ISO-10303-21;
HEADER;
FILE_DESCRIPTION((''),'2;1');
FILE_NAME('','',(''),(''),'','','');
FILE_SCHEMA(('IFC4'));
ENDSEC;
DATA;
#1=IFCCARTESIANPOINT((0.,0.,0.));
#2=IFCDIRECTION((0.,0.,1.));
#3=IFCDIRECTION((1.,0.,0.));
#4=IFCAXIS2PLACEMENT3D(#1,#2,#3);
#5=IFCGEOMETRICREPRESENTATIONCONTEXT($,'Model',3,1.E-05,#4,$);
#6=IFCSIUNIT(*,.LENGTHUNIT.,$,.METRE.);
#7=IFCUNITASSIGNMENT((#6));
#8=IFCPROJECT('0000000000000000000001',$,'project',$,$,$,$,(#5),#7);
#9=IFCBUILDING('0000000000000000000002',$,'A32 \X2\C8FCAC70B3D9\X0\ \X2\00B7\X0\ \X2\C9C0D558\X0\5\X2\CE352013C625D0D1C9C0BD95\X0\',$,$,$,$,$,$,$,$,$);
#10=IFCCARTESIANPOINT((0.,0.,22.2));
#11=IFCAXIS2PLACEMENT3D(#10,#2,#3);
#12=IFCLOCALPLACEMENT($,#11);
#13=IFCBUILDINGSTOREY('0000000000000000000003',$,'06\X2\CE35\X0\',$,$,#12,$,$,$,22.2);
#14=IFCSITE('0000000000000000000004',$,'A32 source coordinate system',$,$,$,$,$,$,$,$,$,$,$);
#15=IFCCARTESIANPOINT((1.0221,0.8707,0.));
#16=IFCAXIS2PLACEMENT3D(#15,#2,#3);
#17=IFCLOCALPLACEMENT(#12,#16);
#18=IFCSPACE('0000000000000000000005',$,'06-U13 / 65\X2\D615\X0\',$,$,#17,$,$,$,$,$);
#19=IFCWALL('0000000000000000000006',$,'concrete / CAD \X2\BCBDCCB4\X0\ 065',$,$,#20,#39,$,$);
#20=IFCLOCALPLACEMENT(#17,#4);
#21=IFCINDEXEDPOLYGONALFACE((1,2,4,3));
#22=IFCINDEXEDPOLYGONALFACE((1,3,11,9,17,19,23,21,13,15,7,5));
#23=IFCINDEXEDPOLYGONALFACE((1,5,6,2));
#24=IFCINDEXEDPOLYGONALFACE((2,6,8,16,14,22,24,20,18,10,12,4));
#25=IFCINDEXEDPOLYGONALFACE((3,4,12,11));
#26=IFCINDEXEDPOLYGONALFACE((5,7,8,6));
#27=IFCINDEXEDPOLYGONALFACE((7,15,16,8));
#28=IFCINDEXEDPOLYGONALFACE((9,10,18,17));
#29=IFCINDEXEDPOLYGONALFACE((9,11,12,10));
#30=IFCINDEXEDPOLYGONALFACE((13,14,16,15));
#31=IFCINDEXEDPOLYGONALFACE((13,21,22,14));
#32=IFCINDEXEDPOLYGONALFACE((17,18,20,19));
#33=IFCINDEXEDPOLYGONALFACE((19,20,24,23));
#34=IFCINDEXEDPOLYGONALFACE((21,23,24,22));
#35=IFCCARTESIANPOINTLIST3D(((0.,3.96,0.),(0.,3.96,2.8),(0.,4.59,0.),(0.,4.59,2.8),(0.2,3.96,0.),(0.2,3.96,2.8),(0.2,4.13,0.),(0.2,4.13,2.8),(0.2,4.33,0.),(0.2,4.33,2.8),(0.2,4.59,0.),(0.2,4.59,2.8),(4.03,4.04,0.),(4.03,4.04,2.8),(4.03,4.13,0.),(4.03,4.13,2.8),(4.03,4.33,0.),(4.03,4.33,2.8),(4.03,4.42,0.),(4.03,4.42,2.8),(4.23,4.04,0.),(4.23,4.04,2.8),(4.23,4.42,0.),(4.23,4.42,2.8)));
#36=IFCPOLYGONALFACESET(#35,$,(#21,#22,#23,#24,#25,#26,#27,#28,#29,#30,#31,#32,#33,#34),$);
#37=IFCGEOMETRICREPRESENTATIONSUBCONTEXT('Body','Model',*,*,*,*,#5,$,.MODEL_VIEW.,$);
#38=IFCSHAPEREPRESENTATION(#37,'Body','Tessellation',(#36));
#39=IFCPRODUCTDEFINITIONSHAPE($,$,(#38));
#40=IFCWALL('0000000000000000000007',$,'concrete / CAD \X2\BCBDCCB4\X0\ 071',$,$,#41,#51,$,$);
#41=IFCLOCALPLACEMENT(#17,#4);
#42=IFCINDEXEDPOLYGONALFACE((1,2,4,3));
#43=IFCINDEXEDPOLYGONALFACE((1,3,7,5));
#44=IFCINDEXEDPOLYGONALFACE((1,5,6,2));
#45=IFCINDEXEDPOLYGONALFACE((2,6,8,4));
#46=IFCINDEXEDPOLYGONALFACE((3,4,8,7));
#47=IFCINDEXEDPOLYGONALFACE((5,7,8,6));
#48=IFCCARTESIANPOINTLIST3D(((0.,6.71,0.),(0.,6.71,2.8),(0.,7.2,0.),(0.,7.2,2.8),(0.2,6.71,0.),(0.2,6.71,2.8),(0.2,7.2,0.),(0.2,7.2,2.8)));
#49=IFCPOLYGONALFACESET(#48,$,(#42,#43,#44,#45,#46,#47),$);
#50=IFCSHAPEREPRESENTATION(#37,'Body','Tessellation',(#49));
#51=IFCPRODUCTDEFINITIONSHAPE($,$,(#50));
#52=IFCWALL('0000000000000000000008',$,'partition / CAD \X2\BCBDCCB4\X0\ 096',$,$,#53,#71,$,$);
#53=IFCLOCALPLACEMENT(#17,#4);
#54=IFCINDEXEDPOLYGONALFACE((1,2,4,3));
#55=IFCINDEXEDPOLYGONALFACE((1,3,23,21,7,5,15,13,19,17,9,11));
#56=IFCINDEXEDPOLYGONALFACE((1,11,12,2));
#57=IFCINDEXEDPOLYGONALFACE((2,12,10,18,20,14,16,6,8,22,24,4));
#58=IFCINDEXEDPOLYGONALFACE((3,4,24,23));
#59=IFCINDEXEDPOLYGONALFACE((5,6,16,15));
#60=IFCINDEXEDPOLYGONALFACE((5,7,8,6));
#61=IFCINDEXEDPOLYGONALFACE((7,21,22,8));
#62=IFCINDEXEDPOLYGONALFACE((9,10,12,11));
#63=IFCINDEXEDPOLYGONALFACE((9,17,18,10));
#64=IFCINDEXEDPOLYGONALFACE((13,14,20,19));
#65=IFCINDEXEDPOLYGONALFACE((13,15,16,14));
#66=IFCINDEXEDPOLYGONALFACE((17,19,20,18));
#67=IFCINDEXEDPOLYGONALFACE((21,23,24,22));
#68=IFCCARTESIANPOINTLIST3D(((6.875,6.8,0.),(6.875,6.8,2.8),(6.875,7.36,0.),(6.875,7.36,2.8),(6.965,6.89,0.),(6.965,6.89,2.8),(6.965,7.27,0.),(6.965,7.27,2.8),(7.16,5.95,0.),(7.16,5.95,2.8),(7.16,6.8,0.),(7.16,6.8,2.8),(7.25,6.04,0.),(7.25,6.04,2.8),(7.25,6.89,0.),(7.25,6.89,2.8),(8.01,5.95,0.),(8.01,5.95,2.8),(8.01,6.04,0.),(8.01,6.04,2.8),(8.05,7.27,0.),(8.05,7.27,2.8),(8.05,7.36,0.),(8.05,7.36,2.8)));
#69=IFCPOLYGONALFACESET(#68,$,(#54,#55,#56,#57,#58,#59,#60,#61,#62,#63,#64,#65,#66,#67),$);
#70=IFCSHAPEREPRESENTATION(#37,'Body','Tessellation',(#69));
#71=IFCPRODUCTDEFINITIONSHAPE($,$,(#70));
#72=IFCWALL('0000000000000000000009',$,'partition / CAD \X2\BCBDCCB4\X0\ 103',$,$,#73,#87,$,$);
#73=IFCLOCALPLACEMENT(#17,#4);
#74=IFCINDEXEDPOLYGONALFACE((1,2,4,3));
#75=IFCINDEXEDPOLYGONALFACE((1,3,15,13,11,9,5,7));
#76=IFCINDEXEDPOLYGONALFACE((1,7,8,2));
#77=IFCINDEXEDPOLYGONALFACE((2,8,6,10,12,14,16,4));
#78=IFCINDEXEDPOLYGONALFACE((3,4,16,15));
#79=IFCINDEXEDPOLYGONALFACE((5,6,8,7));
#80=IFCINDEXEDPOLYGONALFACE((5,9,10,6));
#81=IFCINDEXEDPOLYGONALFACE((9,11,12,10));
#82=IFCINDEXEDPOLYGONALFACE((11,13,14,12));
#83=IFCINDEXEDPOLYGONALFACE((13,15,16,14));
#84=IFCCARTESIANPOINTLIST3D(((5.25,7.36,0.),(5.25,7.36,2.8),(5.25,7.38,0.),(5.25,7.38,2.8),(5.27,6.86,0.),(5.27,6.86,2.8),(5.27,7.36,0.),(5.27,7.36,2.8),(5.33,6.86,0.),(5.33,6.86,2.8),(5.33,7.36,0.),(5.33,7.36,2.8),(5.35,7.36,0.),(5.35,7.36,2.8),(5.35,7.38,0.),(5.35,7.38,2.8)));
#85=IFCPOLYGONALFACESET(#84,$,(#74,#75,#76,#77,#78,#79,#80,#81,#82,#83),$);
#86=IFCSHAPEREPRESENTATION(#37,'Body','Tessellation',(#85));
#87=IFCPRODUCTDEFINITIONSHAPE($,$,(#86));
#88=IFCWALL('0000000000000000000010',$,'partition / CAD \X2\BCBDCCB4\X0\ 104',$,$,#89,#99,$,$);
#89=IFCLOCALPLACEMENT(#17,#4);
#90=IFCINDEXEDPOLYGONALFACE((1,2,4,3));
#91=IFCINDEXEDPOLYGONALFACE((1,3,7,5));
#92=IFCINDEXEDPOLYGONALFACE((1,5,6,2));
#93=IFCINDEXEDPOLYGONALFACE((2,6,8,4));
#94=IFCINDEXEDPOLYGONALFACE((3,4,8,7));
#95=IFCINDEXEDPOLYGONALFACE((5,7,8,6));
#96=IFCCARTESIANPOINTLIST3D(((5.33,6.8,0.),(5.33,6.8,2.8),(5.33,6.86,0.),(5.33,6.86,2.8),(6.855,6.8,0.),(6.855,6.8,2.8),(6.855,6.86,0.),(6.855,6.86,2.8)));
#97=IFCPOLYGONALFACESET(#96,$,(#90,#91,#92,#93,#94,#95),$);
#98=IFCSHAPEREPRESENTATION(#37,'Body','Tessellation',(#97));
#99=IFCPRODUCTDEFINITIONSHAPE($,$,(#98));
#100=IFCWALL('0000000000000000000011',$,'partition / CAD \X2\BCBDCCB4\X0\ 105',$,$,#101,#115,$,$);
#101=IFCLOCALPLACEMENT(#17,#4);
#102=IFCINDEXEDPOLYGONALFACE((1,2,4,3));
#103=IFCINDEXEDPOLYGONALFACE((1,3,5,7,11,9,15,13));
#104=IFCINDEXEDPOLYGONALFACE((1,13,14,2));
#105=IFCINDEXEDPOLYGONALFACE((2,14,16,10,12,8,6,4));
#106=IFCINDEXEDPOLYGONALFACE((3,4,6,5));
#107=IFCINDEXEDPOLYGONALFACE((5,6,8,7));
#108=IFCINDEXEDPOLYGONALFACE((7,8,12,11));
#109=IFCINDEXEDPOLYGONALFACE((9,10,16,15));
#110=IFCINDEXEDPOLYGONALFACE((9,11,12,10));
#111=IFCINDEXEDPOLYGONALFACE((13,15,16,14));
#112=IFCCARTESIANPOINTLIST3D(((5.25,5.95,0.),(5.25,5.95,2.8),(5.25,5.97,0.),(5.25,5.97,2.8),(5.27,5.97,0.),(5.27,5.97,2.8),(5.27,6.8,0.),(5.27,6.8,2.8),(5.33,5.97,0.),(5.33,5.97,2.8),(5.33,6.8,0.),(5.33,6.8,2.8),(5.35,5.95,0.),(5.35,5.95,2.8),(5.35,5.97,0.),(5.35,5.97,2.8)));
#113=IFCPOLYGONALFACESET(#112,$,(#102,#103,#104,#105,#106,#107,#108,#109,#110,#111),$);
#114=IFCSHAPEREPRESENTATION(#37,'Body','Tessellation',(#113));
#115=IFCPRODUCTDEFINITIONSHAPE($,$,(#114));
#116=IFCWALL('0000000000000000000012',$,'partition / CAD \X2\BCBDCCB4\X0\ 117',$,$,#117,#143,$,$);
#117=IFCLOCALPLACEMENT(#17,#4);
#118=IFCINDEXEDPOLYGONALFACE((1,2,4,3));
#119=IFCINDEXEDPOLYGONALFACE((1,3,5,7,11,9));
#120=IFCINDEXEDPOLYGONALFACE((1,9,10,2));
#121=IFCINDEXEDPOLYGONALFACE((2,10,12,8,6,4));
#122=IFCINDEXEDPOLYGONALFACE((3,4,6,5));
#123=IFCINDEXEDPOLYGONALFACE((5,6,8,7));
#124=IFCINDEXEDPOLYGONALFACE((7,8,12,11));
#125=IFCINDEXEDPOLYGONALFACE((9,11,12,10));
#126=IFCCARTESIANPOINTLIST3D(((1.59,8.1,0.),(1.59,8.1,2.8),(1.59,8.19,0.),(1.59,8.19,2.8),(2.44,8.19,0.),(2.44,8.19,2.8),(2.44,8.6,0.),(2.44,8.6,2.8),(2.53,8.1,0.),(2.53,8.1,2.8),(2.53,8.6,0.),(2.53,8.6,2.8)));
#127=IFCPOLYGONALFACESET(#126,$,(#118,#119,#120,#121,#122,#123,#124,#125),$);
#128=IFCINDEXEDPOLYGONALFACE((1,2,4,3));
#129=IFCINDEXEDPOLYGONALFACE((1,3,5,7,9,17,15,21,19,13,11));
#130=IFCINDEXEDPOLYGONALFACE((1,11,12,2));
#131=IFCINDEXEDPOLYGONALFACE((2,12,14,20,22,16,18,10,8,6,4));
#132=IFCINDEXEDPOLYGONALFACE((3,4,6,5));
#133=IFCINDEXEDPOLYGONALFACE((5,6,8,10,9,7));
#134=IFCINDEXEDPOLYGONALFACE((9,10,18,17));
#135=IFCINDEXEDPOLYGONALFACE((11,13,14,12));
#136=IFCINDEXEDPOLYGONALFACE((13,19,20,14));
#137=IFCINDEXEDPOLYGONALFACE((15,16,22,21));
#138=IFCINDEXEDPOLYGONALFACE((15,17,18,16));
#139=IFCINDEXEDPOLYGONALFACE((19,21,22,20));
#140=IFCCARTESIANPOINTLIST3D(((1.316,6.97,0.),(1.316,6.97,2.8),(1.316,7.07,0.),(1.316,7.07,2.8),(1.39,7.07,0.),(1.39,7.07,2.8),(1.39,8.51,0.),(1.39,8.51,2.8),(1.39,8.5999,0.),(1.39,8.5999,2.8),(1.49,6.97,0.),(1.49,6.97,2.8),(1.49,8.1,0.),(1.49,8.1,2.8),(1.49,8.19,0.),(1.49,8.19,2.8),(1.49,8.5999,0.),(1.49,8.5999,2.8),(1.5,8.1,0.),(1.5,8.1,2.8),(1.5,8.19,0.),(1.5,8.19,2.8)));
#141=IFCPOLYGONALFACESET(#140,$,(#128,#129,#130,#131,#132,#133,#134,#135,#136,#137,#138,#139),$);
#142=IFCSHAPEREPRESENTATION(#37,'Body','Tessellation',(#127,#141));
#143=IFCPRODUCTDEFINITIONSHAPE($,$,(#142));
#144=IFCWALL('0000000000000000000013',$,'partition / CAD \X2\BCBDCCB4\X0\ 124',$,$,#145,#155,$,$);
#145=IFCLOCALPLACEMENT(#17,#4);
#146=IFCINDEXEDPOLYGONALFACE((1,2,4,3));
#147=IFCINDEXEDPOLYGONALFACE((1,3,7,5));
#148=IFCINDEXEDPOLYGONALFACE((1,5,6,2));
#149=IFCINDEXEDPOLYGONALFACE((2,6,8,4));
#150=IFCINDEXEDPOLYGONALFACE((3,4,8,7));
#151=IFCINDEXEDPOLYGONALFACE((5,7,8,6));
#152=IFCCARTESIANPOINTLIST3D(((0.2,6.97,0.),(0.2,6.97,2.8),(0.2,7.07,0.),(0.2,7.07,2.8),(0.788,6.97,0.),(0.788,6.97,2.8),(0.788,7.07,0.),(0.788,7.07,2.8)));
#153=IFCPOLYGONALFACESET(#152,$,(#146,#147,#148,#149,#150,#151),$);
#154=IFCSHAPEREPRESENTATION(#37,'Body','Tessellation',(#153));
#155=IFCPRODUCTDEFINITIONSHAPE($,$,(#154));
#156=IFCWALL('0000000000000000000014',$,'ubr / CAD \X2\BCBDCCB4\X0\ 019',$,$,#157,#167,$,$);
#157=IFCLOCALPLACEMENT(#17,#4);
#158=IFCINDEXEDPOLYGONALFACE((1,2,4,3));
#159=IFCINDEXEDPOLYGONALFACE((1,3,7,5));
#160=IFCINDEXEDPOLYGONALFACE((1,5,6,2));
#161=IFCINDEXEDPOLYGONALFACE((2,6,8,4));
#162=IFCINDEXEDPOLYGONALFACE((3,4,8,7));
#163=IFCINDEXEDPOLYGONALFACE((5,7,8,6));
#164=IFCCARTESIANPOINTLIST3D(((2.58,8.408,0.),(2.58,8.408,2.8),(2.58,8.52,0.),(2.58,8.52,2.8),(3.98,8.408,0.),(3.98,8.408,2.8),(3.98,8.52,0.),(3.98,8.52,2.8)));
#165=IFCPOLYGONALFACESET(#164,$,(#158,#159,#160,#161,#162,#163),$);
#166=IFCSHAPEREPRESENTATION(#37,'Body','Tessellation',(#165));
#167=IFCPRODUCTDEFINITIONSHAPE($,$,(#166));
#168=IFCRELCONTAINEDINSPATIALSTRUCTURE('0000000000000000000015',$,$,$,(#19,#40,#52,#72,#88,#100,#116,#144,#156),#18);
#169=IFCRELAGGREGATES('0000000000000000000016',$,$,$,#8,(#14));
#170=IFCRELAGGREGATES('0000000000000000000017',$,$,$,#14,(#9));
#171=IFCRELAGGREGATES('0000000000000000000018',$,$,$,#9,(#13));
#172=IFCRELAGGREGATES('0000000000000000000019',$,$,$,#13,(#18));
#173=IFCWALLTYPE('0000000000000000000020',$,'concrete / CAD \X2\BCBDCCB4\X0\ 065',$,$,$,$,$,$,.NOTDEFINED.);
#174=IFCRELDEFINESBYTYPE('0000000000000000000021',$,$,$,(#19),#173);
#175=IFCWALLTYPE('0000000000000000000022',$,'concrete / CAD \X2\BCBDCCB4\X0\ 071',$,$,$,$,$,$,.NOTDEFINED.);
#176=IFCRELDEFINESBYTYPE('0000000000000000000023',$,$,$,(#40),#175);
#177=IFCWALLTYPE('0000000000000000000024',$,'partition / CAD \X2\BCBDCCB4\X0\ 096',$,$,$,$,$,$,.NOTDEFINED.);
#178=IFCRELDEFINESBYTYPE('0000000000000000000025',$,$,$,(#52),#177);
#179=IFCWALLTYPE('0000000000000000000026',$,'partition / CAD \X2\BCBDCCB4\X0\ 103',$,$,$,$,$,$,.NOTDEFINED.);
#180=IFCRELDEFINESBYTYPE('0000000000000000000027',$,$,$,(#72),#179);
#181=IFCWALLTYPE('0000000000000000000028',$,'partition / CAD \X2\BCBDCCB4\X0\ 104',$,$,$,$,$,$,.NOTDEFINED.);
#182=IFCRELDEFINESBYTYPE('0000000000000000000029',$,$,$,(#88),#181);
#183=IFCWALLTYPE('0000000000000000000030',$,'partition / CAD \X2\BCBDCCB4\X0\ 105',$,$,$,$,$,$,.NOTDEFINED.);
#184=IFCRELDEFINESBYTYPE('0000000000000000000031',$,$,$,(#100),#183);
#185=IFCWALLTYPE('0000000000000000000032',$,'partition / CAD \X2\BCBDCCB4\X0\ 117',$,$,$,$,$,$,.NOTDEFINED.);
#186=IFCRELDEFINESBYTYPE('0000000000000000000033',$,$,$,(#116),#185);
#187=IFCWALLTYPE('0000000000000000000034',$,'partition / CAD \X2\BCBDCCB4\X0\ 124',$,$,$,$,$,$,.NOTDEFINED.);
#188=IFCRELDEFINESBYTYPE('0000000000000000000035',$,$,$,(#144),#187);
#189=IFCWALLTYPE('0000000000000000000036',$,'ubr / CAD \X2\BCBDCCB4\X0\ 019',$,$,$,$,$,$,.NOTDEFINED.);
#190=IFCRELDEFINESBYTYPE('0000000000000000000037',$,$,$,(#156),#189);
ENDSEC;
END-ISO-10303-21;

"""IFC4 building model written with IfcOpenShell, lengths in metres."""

from ifc_helpers import new_model, si_unit, frame, origin, origin_with_axes, place, context, subcontext, project, spatial, polyline, outline, extrude, source, transform, mapped, type_object, type_shapes, element, save


model = new_model("IFC4")

# Units and contexts
model_context = context("Model", 3, precision=1e-05, world=origin_with_axes())
body_context = subcontext(model_context, "Body", "Model", "MODEL_VIEW")
ifc_project = project(units=[si_unit("LENGTHUNIT", "METRE")], contexts=[model_context])

# Site, building, storey, space
storey_placement = place(None, frame((0.0, 0.0, 22.2), z_axis=(0.0, 0.0, 1.0), x_axis=(1.0, 0.0, 0.0)))
space_placement = place(storey_placement, frame((1.0221, 0.8707, 0.0), z_axis=(0.0, 0.0, 1.0), x_axis=(1.0, 0.0, 0.0)))
site = spatial("IfcSite", under=ifc_project, Name="A32 source coordinate system")
building = spatial("IfcBuilding", under=site, Name="A32 주거동 · 지하5층–옥탑지붕")
storey = spatial("IfcBuildingStorey", under=building, at=storey_placement, Name="06층", Elevation=22.2)
space = spatial("IfcSpace", under=storey, at=space_placement, Name="06-U13 / 65형")

# Walls
wall_type_1 = type_object("IfcWallType", Name="concrete / CAD 벽체 065", PredefinedType="NOTDEFINED")
shared_shape_1 = source(origin(), body_context, "Body", "SweptSolid", [
    extrude(outline(polyline([(0.2, 4.59), (0.2, 4.33), (4.03, 4.33), (4.03, 4.42), (4.23, 4.42), (4.23, 4.04), (4.03, 4.04), (4.03, 4.13), (0.2, 4.13), (0.2, 3.96), (0.0, 3.96), (0.0, 4.59), (0.2, 4.59)])), origin(), (0.0, 0.0, 1.0), 2.8),
])
type_shapes(wall_type_1, [shared_shape_1])
wall_1_placement = place(space_placement, origin_with_axes())
element("IfcWall", 1, at=wall_1_placement, inside=space, type_object=wall_type_1, Name="concrete / CAD 벽체 065", context=body_context, shape_type="MappedRepresentation", body=[
    mapped(shared_shape_1, transform((0.0, 0.0, 0.0), scale=1.0)),
])
wall_type_2 = type_object("IfcWallType", Name="concrete / CAD 벽체 071", PredefinedType="NOTDEFINED")
shared_shape_2 = source(origin(), body_context, "Body", "SweptSolid", [
    extrude(outline(polyline([(0.2, 6.71), (0.0, 6.71), (0.0, 7.2), (0.2, 7.2), (0.2, 6.71)])), origin(), (0.0, 0.0, 1.0), 2.8),
])
type_shapes(wall_type_2, [shared_shape_2])
wall_2_placement = place(space_placement, origin_with_axes())
element("IfcWall", 2, at=wall_2_placement, inside=space, type_object=wall_type_2, Name="concrete / CAD 벽체 071", context=body_context, shape_type="MappedRepresentation", body=[
    mapped(shared_shape_2, transform((0.0, 0.0, 0.0), scale=1.0)),
])
wall_type_3 = type_object("IfcWallType", Name="partition / CAD 벽체 096", PredefinedType="NOTDEFINED")
shared_shape_3 = source(origin(), body_context, "Body", "SweptSolid", [
    extrude(outline(polyline([(7.25, 6.04), (8.01, 6.04), (8.01, 5.95), (7.16, 5.95), (7.16, 6.8), (6.875, 6.8), (6.875, 7.36), (8.05, 7.36), (8.05, 7.27), (6.965, 7.27), (6.965, 6.89), (7.25, 6.89), (7.25, 6.04)])), origin(), (0.0, 0.0, 1.0), 2.8),
])
type_shapes(wall_type_3, [shared_shape_3])
wall_3_placement = place(space_placement, origin_with_axes())
element("IfcWall", 3, at=wall_3_placement, inside=space, type_object=wall_type_3, Name="partition / CAD 벽체 096", context=body_context, shape_type="MappedRepresentation", body=[
    mapped(shared_shape_3, transform((0.0, 0.0, 0.0), scale=1.0)),
])
wall_type_4 = type_object("IfcWallType", Name="partition / CAD 벽체 103", PredefinedType="NOTDEFINED")
shared_shape_4 = source(origin(), body_context, "Body", "SweptSolid", [
    extrude(outline(polyline([(5.27, 7.36), (5.25, 7.36), (5.25, 7.38), (5.35, 7.38), (5.35, 7.36), (5.33, 7.36), (5.33, 6.86), (5.27, 6.86), (5.27, 7.36)])), origin(), (0.0, 0.0, 1.0), 2.8),
])
type_shapes(wall_type_4, [shared_shape_4])
wall_4_placement = place(space_placement, origin_with_axes())
element("IfcWall", 4, at=wall_4_placement, inside=space, type_object=wall_type_4, Name="partition / CAD 벽체 103", context=body_context, shape_type="MappedRepresentation", body=[
    mapped(shared_shape_4, transform((0.0, 0.0, 0.0), scale=1.0)),
])
wall_type_5 = type_object("IfcWallType", Name="partition / CAD 벽체 104", PredefinedType="NOTDEFINED")
shared_shape_5 = source(origin(), body_context, "Body", "SweptSolid", [
    extrude(outline(polyline([(6.855, 6.86), (6.855, 6.8), (5.33, 6.8), (5.33, 6.86), (6.855, 6.86)])), origin(), (0.0, 0.0, 1.0), 2.8),
])
type_shapes(wall_type_5, [shared_shape_5])
wall_5_placement = place(space_placement, origin_with_axes())
element("IfcWall", 5, at=wall_5_placement, inside=space, type_object=wall_type_5, Name="partition / CAD 벽체 104", context=body_context, shape_type="MappedRepresentation", body=[
    mapped(shared_shape_5, transform((0.0, 0.0, 0.0), scale=1.0)),
])
wall_type_6 = type_object("IfcWallType", Name="partition / CAD 벽체 105", PredefinedType="NOTDEFINED")
shared_shape_6 = source(origin(), body_context, "Body", "SweptSolid", [
    extrude(outline(polyline([(5.25, 5.97), (5.27, 5.97), (5.27, 6.8), (5.33, 6.8), (5.33, 5.97), (5.35, 5.97), (5.35, 5.95), (5.25, 5.95), (5.25, 5.97)])), origin(), (0.0, 0.0, 1.0), 2.8),
])
type_shapes(wall_type_6, [shared_shape_6])
wall_6_placement = place(space_placement, origin_with_axes())
element("IfcWall", 6, at=wall_6_placement, inside=space, type_object=wall_type_6, Name="partition / CAD 벽체 105", context=body_context, shape_type="MappedRepresentation", body=[
    mapped(shared_shape_6, transform((0.0, 0.0, 0.0), scale=1.0)),
])
wall_type_7 = type_object("IfcWallType", Name="partition / CAD 벽체 117", PredefinedType="NOTDEFINED")
shared_shape_7 = source(origin(), body_context, "Body", "SweptSolid", [
    extrude(outline(polyline([(2.53, 8.1), (1.59, 8.1), (1.59, 8.19), (2.44, 8.19), (2.44, 8.6), (2.53, 8.6), (2.53, 8.1)])), origin(), (0.0, 0.0, 1.0), 2.8),
    extrude(outline(polyline([(1.49, 8.1), (1.49, 6.97), (1.316, 6.97), (1.316, 7.07), (1.39, 7.07), (1.39, 8.51), (1.39, 8.5999), (1.49, 8.5999), (1.49, 8.19), (1.5, 8.19), (1.5, 8.1), (1.49, 8.1)])), origin(), (0.0, 0.0, 1.0), 2.8),
])
type_shapes(wall_type_7, [shared_shape_7])
wall_7_placement = place(space_placement, origin_with_axes())
element("IfcWall", 7, at=wall_7_placement, inside=space, type_object=wall_type_7, Name="partition / CAD 벽체 117", context=body_context, shape_type="MappedRepresentation", body=[
    mapped(shared_shape_7, transform((0.0, 0.0, 0.0), scale=1.0)),
])
wall_type_8 = type_object("IfcWallType", Name="partition / CAD 벽체 124", PredefinedType="NOTDEFINED")
shared_shape_8 = source(origin(), body_context, "Body", "SweptSolid", [
    extrude(outline(polyline([(0.788, 7.07), (0.788, 6.97), (0.2, 6.97), (0.2, 7.07), (0.788, 7.07)])), origin(), (0.0, 0.0, 1.0), 2.8),
])
type_shapes(wall_type_8, [shared_shape_8])
wall_8_placement = place(space_placement, origin_with_axes())
element("IfcWall", 8, at=wall_8_placement, inside=space, type_object=wall_type_8, Name="partition / CAD 벽체 124", context=body_context, shape_type="MappedRepresentation", body=[
    mapped(shared_shape_8, transform((0.0, 0.0, 0.0), scale=1.0)),
])
wall_type_9 = type_object("IfcWallType", Name="ubr / CAD 벽체 019", PredefinedType="NOTDEFINED")
shared_shape_9 = source(origin(), body_context, "Body", "SweptSolid", [
    extrude(outline(polyline([(3.98, 8.408), (2.58, 8.408), (2.58, 8.52), (3.98, 8.52), (3.98, 8.408)])), origin(), (0.0, 0.0, 1.0), 2.8),
])
type_shapes(wall_type_9, [shared_shape_9])
wall_9_placement = place(space_placement, origin_with_axes())
element("IfcWall", 9, at=wall_9_placement, inside=space, type_object=wall_type_9, Name="ubr / CAD 벽체 019", context=body_context, shape_type="MappedRepresentation", body=[
    mapped(shared_shape_9, transform((0.0, 0.0, 0.0), scale=1.0)),
])

save(model, "model.ifc")
